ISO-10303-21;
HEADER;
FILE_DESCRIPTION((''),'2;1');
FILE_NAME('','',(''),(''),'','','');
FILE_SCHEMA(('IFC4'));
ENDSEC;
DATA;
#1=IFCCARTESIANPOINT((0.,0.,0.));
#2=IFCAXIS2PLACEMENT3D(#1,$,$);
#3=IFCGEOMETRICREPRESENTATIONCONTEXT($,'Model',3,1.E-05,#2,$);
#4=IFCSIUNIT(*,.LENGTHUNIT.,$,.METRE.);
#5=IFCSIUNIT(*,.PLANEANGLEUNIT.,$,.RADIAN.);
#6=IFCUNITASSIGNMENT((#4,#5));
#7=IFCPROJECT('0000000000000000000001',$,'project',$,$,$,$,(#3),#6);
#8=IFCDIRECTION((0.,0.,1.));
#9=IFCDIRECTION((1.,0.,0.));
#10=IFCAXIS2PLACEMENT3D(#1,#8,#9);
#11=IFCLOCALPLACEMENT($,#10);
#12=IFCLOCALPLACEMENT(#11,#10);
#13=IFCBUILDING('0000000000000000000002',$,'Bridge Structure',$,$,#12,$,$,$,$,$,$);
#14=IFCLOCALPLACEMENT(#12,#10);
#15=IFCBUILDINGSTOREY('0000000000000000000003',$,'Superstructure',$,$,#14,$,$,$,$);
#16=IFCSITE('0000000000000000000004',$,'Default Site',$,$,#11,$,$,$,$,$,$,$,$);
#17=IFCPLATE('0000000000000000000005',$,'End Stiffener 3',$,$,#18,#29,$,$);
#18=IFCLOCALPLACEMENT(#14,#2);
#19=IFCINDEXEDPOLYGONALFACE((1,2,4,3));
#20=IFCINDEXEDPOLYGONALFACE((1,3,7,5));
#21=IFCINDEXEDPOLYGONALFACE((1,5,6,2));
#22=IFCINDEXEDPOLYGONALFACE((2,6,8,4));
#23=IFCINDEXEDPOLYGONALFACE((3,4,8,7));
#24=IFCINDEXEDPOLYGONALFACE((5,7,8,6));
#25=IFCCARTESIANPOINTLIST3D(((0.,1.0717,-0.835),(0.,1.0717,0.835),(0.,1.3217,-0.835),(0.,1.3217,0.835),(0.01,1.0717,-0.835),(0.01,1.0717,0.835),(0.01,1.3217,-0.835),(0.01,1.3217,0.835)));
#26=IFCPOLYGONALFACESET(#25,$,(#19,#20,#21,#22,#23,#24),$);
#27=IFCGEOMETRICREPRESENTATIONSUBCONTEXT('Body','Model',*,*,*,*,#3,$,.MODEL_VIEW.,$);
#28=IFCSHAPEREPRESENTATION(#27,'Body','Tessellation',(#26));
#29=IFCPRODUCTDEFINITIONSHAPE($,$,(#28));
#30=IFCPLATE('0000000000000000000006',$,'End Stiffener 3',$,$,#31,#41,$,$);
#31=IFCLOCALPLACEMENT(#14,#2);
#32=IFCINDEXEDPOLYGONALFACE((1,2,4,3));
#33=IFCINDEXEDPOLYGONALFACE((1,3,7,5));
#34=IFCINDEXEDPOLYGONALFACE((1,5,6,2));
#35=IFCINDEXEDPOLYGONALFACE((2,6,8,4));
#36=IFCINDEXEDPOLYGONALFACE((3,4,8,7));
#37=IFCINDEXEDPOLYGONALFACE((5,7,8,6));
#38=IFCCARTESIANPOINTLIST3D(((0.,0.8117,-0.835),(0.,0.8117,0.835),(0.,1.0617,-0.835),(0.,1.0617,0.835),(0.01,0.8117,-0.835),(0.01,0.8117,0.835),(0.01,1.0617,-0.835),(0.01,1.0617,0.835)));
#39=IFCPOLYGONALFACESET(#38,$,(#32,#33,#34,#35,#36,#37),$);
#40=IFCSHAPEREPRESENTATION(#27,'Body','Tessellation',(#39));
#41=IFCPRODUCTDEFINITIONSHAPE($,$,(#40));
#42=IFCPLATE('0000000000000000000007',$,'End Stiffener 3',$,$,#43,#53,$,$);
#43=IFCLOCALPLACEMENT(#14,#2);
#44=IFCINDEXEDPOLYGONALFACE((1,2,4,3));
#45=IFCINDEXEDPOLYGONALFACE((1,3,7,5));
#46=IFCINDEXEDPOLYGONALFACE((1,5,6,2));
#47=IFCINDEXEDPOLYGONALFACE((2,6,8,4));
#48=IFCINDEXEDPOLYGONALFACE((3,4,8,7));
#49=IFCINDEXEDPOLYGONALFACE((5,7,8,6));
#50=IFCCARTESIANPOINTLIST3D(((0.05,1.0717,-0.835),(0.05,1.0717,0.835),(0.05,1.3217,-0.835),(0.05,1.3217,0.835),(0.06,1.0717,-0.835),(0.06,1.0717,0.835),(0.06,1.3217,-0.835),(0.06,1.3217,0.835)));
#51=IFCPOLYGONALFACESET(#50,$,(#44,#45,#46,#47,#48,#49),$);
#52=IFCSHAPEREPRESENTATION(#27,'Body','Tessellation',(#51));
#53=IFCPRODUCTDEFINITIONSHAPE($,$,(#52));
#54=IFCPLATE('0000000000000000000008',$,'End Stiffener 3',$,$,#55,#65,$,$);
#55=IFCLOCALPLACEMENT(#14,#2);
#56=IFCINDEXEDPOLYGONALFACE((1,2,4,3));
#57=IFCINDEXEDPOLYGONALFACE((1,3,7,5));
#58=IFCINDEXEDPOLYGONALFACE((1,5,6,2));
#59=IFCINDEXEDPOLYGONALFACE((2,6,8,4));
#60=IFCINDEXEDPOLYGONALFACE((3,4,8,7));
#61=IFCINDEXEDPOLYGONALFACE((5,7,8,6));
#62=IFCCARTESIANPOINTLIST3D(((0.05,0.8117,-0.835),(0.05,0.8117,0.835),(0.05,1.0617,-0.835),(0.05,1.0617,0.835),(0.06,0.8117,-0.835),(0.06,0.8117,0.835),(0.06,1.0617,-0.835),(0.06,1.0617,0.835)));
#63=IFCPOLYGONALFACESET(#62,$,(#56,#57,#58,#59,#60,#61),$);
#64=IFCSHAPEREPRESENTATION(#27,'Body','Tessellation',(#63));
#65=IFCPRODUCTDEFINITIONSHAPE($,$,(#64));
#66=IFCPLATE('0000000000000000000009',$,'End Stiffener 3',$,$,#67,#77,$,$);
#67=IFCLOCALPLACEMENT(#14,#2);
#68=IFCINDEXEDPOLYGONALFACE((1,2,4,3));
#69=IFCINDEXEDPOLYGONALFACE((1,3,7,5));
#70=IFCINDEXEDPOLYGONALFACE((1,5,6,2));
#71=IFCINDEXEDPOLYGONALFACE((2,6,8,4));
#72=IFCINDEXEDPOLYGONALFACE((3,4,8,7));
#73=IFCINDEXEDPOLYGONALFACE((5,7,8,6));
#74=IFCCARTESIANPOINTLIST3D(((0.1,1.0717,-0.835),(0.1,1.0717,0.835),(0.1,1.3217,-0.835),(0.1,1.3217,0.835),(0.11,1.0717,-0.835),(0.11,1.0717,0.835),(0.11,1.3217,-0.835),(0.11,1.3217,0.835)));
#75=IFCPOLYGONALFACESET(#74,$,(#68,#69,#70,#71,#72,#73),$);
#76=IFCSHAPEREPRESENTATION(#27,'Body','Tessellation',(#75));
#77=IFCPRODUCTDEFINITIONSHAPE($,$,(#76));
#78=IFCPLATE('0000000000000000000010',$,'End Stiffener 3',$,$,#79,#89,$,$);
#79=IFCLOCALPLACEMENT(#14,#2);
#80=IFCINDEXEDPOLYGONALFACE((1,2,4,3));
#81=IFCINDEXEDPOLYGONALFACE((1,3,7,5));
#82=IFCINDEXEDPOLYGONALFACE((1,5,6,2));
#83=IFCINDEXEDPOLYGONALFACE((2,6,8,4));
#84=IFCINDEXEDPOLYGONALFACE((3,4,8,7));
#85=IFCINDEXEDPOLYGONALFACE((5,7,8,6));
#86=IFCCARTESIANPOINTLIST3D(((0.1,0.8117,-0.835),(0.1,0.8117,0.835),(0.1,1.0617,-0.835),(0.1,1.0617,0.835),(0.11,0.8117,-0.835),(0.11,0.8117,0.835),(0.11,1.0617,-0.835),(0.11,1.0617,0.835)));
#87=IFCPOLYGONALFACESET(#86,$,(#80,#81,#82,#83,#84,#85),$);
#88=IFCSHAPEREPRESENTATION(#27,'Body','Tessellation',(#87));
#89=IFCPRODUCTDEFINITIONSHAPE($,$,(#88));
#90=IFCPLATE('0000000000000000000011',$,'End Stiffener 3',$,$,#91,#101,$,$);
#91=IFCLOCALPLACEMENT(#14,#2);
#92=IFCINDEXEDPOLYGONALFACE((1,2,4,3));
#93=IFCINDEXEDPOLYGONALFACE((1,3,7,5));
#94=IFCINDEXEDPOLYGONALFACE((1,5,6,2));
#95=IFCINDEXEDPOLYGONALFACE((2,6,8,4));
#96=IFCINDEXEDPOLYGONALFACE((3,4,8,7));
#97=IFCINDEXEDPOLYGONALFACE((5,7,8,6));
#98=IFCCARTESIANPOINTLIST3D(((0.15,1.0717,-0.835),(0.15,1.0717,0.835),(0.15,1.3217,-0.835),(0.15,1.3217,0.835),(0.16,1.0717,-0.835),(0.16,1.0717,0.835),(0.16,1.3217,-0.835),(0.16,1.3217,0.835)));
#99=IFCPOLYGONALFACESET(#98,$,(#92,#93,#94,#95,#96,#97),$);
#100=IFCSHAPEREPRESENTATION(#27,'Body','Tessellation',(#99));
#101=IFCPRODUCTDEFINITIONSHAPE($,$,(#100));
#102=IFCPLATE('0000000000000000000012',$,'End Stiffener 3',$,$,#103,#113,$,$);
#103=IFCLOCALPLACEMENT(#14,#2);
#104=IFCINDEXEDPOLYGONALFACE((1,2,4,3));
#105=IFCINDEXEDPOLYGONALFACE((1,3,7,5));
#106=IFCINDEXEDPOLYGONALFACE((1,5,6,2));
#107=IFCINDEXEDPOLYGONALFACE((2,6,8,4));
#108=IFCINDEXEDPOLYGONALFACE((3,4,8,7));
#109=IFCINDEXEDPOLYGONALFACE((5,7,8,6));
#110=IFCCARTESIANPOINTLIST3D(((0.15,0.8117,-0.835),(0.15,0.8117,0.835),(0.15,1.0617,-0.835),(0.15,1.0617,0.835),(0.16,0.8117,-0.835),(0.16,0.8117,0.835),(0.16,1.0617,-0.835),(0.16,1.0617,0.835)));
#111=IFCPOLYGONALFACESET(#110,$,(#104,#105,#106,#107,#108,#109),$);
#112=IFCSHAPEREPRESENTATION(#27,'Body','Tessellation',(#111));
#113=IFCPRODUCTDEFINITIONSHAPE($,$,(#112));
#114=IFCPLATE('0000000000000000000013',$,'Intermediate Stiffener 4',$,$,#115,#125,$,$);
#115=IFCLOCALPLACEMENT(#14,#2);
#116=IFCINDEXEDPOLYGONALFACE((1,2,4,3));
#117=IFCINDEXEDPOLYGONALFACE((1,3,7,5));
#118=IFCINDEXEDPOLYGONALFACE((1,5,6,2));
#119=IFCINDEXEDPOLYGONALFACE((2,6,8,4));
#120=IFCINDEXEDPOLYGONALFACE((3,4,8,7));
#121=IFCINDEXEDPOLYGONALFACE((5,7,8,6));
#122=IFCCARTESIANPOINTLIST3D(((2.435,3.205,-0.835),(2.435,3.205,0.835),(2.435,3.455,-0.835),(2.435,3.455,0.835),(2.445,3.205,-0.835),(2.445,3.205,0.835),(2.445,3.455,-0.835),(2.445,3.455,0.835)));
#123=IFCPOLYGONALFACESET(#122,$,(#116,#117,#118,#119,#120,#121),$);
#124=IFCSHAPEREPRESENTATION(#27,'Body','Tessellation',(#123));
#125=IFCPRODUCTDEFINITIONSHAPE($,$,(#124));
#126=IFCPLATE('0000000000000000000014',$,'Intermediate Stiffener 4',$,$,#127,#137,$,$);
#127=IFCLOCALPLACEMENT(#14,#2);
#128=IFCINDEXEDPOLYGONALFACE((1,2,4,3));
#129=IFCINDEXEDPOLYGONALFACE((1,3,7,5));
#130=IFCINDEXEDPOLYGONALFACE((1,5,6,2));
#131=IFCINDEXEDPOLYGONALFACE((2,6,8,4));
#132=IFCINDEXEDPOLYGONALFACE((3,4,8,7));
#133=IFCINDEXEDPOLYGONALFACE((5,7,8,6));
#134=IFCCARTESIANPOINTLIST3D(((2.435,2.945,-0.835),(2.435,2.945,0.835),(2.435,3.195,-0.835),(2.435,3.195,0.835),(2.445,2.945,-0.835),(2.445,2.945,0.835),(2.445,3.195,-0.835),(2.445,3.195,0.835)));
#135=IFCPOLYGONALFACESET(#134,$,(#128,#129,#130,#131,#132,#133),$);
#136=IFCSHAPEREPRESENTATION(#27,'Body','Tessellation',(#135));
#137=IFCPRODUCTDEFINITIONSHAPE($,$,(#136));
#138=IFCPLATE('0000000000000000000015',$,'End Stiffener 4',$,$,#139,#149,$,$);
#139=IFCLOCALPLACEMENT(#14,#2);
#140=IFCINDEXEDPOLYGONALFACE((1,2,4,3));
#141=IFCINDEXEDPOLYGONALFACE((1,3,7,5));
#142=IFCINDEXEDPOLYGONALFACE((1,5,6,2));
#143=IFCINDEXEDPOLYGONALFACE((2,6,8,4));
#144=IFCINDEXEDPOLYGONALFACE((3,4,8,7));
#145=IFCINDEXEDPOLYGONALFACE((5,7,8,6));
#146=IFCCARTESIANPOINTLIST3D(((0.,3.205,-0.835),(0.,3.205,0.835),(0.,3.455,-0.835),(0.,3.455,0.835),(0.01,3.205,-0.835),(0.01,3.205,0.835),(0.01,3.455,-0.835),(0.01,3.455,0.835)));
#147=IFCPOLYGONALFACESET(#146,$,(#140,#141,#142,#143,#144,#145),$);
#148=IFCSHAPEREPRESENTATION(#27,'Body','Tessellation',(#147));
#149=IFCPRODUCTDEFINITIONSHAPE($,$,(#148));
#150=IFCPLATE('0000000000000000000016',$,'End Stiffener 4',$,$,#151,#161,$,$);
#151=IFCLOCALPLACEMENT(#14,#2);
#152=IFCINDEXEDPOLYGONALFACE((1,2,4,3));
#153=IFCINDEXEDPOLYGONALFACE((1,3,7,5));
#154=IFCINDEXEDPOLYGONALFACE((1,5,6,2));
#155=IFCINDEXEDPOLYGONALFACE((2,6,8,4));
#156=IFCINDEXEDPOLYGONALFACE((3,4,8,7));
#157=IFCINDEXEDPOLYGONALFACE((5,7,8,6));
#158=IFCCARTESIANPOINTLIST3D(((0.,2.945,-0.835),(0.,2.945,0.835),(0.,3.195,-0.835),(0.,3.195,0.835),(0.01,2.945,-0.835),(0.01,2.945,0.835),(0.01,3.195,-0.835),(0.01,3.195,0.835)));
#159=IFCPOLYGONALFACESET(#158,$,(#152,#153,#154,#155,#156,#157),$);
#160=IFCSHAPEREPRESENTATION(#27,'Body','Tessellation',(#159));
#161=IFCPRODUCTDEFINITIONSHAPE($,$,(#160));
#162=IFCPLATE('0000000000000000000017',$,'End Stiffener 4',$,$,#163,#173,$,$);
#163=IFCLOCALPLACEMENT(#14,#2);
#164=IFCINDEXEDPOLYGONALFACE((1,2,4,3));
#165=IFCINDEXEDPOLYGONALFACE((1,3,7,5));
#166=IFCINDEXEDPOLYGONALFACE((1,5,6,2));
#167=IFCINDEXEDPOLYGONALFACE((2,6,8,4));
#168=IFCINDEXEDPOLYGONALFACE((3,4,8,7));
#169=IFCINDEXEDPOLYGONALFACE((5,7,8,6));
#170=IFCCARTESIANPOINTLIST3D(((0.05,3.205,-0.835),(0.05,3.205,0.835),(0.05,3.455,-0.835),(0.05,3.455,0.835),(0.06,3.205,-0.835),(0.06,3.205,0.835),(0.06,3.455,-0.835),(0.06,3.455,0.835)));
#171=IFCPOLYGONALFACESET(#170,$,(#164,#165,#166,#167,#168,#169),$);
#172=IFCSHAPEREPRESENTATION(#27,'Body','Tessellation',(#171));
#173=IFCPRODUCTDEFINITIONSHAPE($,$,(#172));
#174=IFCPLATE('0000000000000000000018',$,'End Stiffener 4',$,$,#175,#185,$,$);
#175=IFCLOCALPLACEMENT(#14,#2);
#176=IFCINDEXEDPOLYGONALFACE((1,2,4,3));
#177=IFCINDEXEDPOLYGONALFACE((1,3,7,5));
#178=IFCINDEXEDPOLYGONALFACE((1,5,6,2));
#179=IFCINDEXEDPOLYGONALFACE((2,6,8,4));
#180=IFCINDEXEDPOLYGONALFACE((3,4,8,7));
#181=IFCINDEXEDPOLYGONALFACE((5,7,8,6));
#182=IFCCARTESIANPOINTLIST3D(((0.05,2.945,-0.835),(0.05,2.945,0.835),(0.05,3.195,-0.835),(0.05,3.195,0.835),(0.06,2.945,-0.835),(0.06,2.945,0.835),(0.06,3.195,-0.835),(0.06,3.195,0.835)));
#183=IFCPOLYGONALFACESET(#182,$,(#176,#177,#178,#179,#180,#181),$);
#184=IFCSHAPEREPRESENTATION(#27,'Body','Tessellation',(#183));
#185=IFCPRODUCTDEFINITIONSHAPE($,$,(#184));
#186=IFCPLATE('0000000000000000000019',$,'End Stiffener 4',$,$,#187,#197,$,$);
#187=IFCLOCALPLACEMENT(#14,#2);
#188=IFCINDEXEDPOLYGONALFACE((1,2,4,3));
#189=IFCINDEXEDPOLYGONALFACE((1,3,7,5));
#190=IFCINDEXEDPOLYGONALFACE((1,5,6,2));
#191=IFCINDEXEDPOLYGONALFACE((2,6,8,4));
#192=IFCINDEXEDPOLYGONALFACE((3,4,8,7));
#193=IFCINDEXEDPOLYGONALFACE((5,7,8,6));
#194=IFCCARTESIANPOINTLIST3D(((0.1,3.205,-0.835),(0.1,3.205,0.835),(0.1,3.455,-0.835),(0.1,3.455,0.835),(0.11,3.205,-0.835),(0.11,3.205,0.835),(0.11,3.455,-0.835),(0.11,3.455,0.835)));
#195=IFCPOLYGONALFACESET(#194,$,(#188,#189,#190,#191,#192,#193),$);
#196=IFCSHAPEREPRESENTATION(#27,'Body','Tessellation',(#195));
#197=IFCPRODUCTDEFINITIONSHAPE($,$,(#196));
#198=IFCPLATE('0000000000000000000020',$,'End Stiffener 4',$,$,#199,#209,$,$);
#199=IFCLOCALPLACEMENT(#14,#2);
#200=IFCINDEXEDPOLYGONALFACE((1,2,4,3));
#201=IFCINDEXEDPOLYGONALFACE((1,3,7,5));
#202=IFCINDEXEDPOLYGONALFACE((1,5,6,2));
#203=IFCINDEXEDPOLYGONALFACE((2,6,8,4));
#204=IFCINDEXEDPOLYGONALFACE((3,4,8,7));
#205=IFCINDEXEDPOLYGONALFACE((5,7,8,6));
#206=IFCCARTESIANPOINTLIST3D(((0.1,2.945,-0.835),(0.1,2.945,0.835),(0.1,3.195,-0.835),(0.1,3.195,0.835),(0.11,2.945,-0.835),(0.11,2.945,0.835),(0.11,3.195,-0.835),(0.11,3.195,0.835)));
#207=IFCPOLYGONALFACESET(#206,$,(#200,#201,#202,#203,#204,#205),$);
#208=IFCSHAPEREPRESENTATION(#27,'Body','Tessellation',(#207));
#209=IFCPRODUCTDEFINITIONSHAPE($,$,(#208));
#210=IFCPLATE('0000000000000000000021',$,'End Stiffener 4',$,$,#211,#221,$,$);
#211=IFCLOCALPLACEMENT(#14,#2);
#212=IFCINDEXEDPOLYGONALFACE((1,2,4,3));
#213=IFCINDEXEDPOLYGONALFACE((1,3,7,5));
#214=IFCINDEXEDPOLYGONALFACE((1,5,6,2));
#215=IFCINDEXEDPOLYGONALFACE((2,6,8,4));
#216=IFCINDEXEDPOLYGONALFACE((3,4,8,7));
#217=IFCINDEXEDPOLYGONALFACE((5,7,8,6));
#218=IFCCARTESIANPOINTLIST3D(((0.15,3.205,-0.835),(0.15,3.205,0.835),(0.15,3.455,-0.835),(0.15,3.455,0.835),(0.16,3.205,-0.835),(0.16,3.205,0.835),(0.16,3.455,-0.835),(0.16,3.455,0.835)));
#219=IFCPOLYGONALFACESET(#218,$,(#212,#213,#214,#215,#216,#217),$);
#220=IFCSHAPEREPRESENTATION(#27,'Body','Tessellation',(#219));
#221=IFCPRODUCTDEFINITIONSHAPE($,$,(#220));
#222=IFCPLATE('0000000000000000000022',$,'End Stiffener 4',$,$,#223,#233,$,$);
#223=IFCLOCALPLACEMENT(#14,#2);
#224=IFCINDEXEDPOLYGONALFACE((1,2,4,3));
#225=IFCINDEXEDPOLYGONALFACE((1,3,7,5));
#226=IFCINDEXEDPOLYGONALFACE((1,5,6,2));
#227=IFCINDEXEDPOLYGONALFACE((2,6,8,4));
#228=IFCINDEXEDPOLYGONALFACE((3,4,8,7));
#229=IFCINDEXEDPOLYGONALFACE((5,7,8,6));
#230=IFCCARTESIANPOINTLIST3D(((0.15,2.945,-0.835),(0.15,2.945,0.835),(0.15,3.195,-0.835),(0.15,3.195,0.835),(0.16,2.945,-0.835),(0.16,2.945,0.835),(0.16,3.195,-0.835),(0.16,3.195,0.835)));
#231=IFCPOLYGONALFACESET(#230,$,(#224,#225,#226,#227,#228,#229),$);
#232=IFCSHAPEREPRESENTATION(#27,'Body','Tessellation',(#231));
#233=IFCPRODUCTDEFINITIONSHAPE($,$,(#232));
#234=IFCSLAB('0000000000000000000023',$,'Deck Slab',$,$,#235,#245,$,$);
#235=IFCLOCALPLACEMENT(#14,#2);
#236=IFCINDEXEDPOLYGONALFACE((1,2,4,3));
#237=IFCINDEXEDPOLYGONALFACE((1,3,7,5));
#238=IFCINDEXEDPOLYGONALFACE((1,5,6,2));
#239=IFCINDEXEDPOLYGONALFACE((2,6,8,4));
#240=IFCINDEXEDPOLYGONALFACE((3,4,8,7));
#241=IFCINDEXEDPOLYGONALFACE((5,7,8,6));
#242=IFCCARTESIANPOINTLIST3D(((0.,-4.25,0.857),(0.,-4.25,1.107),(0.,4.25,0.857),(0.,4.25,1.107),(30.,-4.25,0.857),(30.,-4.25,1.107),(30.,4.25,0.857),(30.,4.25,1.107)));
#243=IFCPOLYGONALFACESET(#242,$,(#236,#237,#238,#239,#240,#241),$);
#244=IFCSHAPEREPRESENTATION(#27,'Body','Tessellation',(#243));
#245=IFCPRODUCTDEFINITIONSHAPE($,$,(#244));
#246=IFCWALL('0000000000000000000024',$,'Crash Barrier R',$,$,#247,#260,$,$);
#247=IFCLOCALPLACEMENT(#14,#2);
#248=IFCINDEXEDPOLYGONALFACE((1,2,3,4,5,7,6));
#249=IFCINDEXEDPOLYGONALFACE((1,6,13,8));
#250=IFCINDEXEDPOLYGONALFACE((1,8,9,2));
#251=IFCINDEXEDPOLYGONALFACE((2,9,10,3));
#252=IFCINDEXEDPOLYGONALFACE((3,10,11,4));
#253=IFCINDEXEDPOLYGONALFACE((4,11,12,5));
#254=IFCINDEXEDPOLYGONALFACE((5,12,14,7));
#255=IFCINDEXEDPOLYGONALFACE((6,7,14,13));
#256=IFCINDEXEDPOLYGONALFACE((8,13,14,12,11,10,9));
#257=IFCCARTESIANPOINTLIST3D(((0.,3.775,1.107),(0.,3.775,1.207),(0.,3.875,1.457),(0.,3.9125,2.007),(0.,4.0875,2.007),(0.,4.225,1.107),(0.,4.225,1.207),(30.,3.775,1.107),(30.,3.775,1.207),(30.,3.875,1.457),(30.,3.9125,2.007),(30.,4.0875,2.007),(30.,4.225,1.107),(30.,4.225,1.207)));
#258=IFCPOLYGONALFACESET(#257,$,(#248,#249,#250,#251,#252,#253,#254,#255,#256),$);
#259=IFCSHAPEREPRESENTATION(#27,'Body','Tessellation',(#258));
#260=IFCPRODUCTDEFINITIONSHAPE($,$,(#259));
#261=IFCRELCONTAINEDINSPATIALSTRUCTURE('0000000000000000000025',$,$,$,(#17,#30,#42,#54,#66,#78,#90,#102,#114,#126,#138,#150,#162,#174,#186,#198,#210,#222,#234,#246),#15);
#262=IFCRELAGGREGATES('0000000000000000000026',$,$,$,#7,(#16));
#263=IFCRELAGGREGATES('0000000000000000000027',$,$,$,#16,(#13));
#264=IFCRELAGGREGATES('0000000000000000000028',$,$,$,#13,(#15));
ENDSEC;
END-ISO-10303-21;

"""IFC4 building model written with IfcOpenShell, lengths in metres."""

from ifc_helpers import new_model, si_unit, frame, origin, origin_with_axes, origin_2d_with_axis, place, context, subcontext, project, spatial, polyline, rectangle, outline, extrude, element, save


model = new_model("IFC4")

# Units and contexts
model_context = context("Model", 3, precision=1e-05, world=origin())
body_context = subcontext(model_context, "Body", "Model", "MODEL_VIEW")
ifc_project = project(units=[si_unit("LENGTHUNIT", "METRE"), si_unit("PLANEANGLEUNIT", "RADIAN")], contexts=[model_context])

# Site, building, storey
site_placement = place(None, origin_with_axes())
site = spatial("IfcSite", under=ifc_project, at=site_placement, Name="Default Site")
building_placement = place(site_placement, origin_with_axes())
building = spatial("IfcBuilding", under=site, at=building_placement, Name="Bridge Structure")
storey_placement = place(building_placement, origin_with_axes())
storey = spatial("IfcBuildingStorey", under=building, at=storey_placement, Name="Superstructure")

# Plates
for number, where, z_axis, x_axis, name in (
    (1, (0.005, 1.1967, -0.835), (0.0, 0.0, 1.0), (1.0, 0.0, 0.0), "End Stiffener 3"),
    (2, (0.005, 0.9367, -0.835), (0.0, 0.0, 1.0), (1.0, 0.0, 0.0), "End Stiffener 3"),
    (3, (0.055, 1.1967, -0.835), (0.0, 0.0, 1.0), (1.0, 0.0, 0.0), "End Stiffener 3"),
    (4, (0.055, 0.9367, -0.835), (0.0, 0.0, 1.0), (1.0, 0.0, 0.0), "End Stiffener 3"),
    (5, (0.105, 1.1967, -0.835), (0.0, 0.0, 1.0), (1.0, 0.0, 0.0), "End Stiffener 3"),
    (6, (0.105, 0.9367, -0.835), (0.0, 0.0, 1.0), (1.0, 0.0, 0.0), "End Stiffener 3"),
    (7, (0.155, 1.1967, -0.835), (0.0, 0.0, 1.0), (1.0, 0.0, 0.0), "End Stiffener 3"),
    (8, (0.155, 0.9367, -0.835), (0.0, 0.0, 1.0), (1.0, 0.0, 0.0), "End Stiffener 3"),
    (9, (2.44, 3.33, -0.835), (0.0, 0.0, 1.0), (1.0, 0.0, 0.0), "Intermediate Stiffener 4"),
    (10, (2.44, 3.07, -0.835), (0.0, 0.0, 1.0), (1.0, 0.0, 0.0), "Intermediate Stiffener 4"),
    (11, (0.005, 3.33, -0.835), (0.0, 0.0, 1.0), (1.0, 0.0, 0.0), "End Stiffener 4"),
    (12, (0.005, 3.07, -0.835), (0.0, 0.0, 1.0), (1.0, 0.0, 0.0), "End Stiffener 4"),
    (13, (0.055, 3.33, -0.835), (0.0, 0.0, 1.0), (1.0, 0.0, 0.0), "End Stiffener 4"),
    (14, (0.055, 3.07, -0.835), (0.0, 0.0, 1.0), (1.0, 0.0, 0.0), "End Stiffener 4"),
    (15, (0.105, 3.33, -0.835), (0.0, 0.0, 1.0), (1.0, 0.0, 0.0), "End Stiffener 4"),
    (16, (0.105, 3.07, -0.835), (0.0, 0.0, 1.0), (1.0, 0.0, 0.0), "End Stiffener 4"),
    (17, (0.155, 3.33, -0.835), (0.0, 0.0, 1.0), (1.0, 0.0, 0.0), "End Stiffener 4"),
    (18, (0.155, 3.07, -0.835), (0.0, 0.0, 1.0), (1.0, 0.0, 0.0), "End Stiffener 4"),
):
    element("IfcPlate", number, at=place(storey_placement, frame(where, z_axis=z_axis, x_axis=x_axis)), inside=storey, Name=name, context=body_context, shape_type="SweptSolid", body=[
        extrude(rectangle(XDim=0.01, YDim=0.25, at=origin_2d_with_axis()), origin_with_axes(), (0.0, 0.0, 1.0), 1.67),
    ])

# Slab
slab_placement = place(storey_placement, frame((0.0, 0.0, 0.857), z_axis=(0.0, 0.0, 1.0), x_axis=(1.0, 0.0, 0.0)))
element("IfcSlab", 19, at=slab_placement, inside=storey, Name="Deck Slab", context=body_context, shape_type="SweptSolid", body=[
    extrude(outline(polyline([(0.0, -4.25), (30.0, -4.25), (30.0, 4.25), (0.0, 4.25), (0.0, -4.25)])), origin_with_axes(), (0.0, 0.0, 1.0), 0.25),
])

# Wall
wall_placement = place(storey_placement, frame((0.0, 3.775, 1.107), z_axis=(1.0, 0.0, 0.0), x_axis=(0.0, 1.0, 0.0)))
element("IfcWall", 20, at=wall_placement, inside=storey, Name="Crash Barrier R", context=body_context, shape_type="SweptSolid", body=[
    extrude(outline(polyline([(0.45, 0.0), (0.0, 0.0), (0.0, 0.1), (0.1, 0.35), (0.1375, 0.9), (0.3125, 0.9), (0.45, 0.1), (0.45, 0.0)])), origin_with_axes(), (0.0, 0.0, 1.0), 30.0),
])

save(model, "model.ifc")
